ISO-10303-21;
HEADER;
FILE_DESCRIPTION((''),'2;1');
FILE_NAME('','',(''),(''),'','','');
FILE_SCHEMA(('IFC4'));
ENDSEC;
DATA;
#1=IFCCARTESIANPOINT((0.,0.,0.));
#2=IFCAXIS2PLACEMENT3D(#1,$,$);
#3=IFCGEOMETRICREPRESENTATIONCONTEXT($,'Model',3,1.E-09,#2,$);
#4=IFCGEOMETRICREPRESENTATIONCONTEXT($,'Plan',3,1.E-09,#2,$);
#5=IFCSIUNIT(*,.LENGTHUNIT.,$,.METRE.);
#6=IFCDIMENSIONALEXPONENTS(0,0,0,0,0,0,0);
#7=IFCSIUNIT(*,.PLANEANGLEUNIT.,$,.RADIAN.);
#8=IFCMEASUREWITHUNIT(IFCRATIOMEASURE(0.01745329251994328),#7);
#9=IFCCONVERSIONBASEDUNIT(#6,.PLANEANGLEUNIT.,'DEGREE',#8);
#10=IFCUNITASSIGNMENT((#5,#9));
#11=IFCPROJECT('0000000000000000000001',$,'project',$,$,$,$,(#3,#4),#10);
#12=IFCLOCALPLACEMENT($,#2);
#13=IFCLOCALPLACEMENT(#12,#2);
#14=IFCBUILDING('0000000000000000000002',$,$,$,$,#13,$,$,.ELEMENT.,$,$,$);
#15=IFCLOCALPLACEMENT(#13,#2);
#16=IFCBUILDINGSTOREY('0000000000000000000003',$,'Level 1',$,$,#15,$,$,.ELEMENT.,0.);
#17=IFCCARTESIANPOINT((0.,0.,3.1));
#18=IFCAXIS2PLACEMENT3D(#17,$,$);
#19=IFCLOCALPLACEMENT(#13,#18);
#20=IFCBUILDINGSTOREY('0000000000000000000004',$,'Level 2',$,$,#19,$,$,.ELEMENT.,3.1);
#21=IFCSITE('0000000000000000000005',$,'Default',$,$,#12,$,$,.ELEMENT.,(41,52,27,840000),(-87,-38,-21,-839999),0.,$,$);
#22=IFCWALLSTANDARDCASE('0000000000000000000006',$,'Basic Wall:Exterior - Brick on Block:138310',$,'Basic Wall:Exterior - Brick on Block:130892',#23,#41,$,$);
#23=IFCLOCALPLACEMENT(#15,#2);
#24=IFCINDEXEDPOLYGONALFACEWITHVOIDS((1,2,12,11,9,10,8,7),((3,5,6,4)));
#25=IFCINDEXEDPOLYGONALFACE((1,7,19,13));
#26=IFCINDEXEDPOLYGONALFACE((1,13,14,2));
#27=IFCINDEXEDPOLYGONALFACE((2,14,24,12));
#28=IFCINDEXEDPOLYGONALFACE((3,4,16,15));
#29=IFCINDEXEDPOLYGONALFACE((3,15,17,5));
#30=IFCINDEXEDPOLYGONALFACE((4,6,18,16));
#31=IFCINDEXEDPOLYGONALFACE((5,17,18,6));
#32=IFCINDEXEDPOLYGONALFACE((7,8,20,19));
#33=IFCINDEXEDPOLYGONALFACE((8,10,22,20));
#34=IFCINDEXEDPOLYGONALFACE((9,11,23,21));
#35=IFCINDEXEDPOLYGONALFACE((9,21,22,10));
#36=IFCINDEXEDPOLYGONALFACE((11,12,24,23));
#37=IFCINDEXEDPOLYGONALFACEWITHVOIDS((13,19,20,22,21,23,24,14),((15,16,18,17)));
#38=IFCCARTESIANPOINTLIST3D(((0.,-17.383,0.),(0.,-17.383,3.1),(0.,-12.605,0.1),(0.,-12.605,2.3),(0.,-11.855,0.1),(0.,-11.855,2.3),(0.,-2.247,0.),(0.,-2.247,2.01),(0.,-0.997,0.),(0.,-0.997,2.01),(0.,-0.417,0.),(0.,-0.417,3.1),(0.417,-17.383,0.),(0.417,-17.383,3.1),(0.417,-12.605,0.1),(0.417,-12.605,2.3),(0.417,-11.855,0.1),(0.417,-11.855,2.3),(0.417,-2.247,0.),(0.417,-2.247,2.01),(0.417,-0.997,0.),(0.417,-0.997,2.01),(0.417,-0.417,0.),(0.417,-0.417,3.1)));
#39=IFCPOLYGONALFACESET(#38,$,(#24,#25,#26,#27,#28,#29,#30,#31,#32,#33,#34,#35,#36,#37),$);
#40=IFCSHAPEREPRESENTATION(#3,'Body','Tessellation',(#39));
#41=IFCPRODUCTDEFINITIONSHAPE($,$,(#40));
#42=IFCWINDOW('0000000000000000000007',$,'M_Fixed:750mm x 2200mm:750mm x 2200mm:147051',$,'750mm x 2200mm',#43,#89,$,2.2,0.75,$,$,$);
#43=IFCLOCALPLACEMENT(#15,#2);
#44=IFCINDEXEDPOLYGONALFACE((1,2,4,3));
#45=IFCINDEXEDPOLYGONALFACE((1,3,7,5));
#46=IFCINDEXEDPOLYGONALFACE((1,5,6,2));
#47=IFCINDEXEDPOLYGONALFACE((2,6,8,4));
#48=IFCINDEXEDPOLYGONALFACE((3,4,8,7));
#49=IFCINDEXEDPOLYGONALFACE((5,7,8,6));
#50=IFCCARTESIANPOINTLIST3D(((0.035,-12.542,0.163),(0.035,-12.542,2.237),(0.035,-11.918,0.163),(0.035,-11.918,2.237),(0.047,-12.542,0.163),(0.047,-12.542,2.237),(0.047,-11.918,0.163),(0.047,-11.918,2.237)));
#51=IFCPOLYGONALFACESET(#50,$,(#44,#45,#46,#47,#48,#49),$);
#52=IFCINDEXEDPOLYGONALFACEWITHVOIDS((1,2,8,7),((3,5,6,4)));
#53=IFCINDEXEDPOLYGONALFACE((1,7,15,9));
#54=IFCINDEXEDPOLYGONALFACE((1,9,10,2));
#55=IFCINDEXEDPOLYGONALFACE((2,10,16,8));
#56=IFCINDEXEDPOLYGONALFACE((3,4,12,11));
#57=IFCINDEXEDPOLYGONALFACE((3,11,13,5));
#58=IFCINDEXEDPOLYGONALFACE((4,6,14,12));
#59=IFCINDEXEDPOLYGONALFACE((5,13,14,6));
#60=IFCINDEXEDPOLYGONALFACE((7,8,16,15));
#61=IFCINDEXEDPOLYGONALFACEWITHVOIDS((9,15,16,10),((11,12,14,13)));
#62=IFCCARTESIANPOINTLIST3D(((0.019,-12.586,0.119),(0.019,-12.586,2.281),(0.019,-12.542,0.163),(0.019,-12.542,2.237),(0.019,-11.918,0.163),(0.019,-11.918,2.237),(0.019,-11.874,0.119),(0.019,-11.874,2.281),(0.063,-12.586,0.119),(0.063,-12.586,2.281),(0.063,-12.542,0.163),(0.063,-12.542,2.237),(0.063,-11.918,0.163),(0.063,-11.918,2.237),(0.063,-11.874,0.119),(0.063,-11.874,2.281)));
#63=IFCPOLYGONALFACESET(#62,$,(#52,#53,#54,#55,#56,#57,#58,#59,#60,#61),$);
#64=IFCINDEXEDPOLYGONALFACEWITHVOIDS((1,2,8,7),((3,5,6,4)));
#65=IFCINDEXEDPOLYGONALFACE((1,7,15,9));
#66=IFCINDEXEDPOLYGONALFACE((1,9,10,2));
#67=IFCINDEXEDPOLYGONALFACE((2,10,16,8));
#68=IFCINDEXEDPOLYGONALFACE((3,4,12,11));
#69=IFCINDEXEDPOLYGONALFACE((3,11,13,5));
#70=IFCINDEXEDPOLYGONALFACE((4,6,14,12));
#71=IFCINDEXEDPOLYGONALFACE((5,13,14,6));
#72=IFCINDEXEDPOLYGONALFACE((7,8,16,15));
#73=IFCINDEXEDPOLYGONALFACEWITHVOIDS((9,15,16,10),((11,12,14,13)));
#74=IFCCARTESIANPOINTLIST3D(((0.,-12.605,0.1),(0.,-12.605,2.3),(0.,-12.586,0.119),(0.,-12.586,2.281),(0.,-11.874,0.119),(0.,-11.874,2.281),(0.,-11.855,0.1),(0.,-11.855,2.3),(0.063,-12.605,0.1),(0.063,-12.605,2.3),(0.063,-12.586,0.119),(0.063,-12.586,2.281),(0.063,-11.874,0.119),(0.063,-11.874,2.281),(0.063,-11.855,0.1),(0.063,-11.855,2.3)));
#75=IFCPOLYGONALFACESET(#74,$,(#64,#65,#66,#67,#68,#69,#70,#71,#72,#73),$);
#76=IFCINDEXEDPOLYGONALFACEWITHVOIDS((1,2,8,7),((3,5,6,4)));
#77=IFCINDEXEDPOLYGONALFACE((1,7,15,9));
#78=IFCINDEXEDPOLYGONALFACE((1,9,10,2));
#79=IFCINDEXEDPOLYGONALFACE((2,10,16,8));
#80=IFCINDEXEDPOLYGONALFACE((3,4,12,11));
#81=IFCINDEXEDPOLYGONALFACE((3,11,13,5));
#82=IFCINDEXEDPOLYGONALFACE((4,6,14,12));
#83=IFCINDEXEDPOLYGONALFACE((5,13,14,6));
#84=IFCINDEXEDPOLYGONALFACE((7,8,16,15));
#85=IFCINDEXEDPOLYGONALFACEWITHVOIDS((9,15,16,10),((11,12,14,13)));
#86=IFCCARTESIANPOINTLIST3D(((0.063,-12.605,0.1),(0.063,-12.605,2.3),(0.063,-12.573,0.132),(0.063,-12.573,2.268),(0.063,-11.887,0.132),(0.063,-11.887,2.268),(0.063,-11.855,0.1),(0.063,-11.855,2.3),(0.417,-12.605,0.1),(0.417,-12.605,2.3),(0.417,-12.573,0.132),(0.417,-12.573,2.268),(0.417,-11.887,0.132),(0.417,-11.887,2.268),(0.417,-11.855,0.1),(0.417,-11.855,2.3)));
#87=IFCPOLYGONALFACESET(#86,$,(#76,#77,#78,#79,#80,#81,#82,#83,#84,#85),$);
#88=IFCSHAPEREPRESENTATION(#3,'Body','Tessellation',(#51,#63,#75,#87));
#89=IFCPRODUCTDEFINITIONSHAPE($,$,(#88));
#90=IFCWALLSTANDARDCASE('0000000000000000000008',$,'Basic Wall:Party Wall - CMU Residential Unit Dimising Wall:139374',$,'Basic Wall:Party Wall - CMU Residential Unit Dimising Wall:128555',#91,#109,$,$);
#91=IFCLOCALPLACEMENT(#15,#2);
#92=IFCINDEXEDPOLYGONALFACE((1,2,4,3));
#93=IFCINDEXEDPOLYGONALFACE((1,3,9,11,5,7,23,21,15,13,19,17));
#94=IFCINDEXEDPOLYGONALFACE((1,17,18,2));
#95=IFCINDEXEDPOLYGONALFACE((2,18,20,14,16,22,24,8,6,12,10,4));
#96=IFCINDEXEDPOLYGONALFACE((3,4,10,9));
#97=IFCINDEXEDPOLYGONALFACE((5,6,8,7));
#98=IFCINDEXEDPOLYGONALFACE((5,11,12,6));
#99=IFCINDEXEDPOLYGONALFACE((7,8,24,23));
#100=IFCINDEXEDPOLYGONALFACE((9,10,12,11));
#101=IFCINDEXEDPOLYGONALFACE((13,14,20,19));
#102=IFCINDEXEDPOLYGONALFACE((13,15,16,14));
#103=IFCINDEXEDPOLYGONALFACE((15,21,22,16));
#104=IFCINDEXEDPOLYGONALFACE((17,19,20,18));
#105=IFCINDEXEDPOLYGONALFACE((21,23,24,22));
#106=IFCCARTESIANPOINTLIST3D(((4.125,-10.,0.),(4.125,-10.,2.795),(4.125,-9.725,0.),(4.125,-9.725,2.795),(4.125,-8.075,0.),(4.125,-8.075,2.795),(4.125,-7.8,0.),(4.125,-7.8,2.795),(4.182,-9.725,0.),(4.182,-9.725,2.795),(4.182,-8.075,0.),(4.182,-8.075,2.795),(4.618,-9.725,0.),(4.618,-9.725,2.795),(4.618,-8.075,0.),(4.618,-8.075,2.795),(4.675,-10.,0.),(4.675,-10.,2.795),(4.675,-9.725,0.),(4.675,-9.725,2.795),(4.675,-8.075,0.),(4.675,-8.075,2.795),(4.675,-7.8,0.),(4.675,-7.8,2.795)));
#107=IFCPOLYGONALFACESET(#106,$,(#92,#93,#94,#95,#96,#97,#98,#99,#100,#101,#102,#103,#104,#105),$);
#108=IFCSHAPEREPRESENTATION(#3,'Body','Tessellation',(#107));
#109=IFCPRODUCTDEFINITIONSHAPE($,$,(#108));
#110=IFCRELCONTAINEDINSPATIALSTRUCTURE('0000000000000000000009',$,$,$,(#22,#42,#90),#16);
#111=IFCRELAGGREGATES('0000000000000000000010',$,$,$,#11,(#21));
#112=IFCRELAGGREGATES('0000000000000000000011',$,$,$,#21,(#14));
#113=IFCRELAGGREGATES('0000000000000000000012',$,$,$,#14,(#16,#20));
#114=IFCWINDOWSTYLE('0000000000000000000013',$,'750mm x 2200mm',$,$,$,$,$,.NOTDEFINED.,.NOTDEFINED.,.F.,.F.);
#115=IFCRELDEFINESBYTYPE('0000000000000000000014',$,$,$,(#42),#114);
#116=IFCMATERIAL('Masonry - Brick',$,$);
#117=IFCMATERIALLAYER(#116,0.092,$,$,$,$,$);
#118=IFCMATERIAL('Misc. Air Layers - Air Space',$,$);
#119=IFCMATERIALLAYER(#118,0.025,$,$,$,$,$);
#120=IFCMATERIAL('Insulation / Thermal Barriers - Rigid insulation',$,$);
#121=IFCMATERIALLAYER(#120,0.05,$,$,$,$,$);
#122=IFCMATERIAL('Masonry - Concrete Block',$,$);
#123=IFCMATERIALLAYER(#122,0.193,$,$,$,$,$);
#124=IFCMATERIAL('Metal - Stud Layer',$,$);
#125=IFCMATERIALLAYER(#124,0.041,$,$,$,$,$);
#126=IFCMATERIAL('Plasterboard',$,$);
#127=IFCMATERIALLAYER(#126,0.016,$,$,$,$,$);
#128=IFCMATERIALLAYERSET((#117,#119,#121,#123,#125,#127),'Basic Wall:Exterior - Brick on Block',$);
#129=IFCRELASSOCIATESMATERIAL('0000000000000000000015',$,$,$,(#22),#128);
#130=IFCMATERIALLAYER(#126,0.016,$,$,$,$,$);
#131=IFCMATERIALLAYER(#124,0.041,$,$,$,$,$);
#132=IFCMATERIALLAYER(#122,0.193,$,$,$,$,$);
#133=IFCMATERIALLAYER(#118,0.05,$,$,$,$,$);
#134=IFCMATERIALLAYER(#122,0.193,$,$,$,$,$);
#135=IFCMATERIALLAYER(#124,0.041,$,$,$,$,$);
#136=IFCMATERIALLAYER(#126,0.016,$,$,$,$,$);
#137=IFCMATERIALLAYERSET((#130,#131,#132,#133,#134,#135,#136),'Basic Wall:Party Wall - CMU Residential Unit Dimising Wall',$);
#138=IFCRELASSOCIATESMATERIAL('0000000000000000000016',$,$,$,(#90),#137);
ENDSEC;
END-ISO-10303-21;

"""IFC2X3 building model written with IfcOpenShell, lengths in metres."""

from ifc_helpers import new_model, entity, si_unit, converted_unit, frame, frame_2d, origin, origin_2d_with_axis, place, context, project, spatial, polyline, rectangle, outline, extrude, clip, bounded_halfspace, source, transform, mapped, material, layer, layer_set, layer_usage, type_object, type_shapes, element, fill, save


model = new_model("IFC2X3")

# Units and contexts
model_context = context("Model", 3, precision=1e-09, world=origin())
plan_context = context("Plan", 3, precision=1e-09, world=origin())
ifc_project = project(units=[si_unit("LENGTHUNIT", "METRE"), converted_unit("PLANEANGLEUNIT", "DEGREE", entity("IfcRatioMeasure", 0.01745329251994328), si_unit("PLANEANGLEUNIT", "RADIAN"), dimensions=[0, 0, 0, 0, 0, 0, 0])], contexts=[model_context, plan_context])

# Site, building, storey
site_placement = place(None, origin())
site = spatial("IfcSite", under=ifc_project, at=site_placement, Name="Default", CompositionType="ELEMENT", RefLatitude=(41, 52, 27, 840000), RefLongitude=(-87, -38, -21, -839999), RefElevation=0.0)
building_placement = place(site_placement, origin())
building = spatial("IfcBuilding", under=site, at=building_placement, CompositionType="ELEMENT")
storey_1_placement = place(building_placement, origin())
storey_1 = spatial("IfcBuildingStorey", under=building, at=storey_1_placement, Name="Level 1", CompositionType="ELEMENT", Elevation=0.0)

# Shared definitions
ifc_material_1 = material(Name="Masonry - Brick")
ifc_layer_1 = layer(ifc_material_1, 0.092)
ifc_material_2 = material(Name="Misc. Air Layers - Air Space")
ifc_layer_2 = layer(ifc_material_2, 0.025)
ifc_material_3 = material(Name="Insulation / Thermal Barriers - Rigid insulation")
ifc_layer_3 = layer(ifc_material_3, 0.05)
ifc_material_4 = material(Name="Masonry - Concrete Block")
ifc_layer_4 = layer(ifc_material_4, 0.193)
ifc_material_5 = material(Name="Metal - Stud Layer")
ifc_layer_5 = layer(ifc_material_5, 0.041)
ifc_material_6 = material(Name="Plasterboard")
ifc_layer_6 = layer(ifc_material_6, 0.016)
ifc_layer_set_1 = layer_set([ifc_layer_1, ifc_layer_2, ifc_layer_3, ifc_layer_4, ifc_layer_5, ifc_layer_6], Name="Basic Wall:Exterior - Brick on Block")

# Wall, openings, window
ifc_layer_usage_1 = layer_usage(ifc_layer_set_1, "AXIS2", "NEGATIVE", 0.2085)
wall_1_placement = place(storey_1_placement, frame((0.2085, -17.383, 0.0), z_axis=(0.0, 0.0, 1.0), x_axis=(0.0, 1.0, 0.0)))
wall_1 = element("IfcWallStandardCase", 1, at=wall_1_placement, inside=storey_1, material=ifc_layer_usage_1, Name="Basic Wall:Exterior - Brick on Block:138310", ObjectType="Basic Wall:Exterior - Brick on Block:130892", context=model_context, shape_type="SweptSolid", body=[
    extrude(rectangle(XDim=16.966, YDim=0.417, at=frame_2d((8.483, 0.0), x_axis=(-1.0, 0.0))), origin(), (0.0, 0.0, 1.0), 3.1),
])
opening_1_placement = place(wall_1_placement, frame((15.136, -0.2085, 0.0)))
element("IfcOpeningElement", 2, at=opening_1_placement, cuts=wall_1, ObjectType="Opening", context=model_context, shape_type="SweptSolid", body=[
    extrude(rectangle(XDim=1.25, YDim=2.01, at=frame_2d((1.005, 0.625), x_axis=(0.0, 1.0))), frame((0.0, 0.0, 0.0), z_axis=(0.0, 1.0, 0.0), x_axis=(0.0, 0.0, 1.0)), (0.0, 0.0, 1.0), 0.417),
])
opening_2_placement = place(wall_1_placement, frame((4.778, -0.2085, 0.1)))
opening_2 = element("IfcOpeningElement", 3, at=opening_2_placement, cuts=wall_1, ObjectType="Opening", context=model_context, shape_type="SweptSolid", body=[
    extrude(rectangle(XDim=2.2, YDim=0.75, at=frame_2d((1.1, 0.375), x_axis=(1.0, 0.0))), frame((0.0, 0.0, 0.0), z_axis=(0.0, 1.0, 0.0), x_axis=(0.0, 0.0, 1.0)), (0.0, 0.0, 1.0), 0.417),
])
window_style_1 = type_object("IfcWindowStyle", Name="750mm x 2200mm", ConstructionType="NOTDEFINED", OperationType="NOTDEFINED", ParameterTakesPrecedence=False, Sizeable=False)
shared_shape_1 = source(origin(), model_context, "Body", "SweptSolid", [
    extrude(rectangle(XDim=0.012, YDim=0.624, at=origin_2d_with_axis()), frame((0.375, 0.376, 0.063), z_axis=(0.0, 0.0, 1.0), x_axis=(0.0, -1.0, 0.0)), (0.0, 0.0, 1.0), 2.074),
    extrude(outline(polyline([(-0.356, -1.081), (0.356, -1.081), (0.356, 1.081), (-0.356, 1.081), (-0.356, -1.081)]), holes=[polyline([(-0.312, -1.037), (-0.312, 1.037), (0.312, 1.037), (0.312, -1.037), (-0.312, -1.037)])]), frame((0.375, 0.354, 1.1), z_axis=(0.0, 1.0, 0.0), x_axis=(1.0, 0.0, 0.0)), (0.0, 0.0, 1.0), 0.044),
    extrude(outline(polyline([(-0.375, -1.1), (0.375, -1.1), (0.375, 1.1), (-0.375, 1.1), (-0.375, -1.1)]), holes=[polyline([(-0.356, -1.081), (-0.356, 1.081), (0.356, 1.081), (0.356, -1.081), (-0.356, -1.081)])]), frame((0.375, 0.354, 1.1), z_axis=(0.0, 1.0, 0.0), x_axis=(1.0, 0.0, 0.0)), (0.0, 0.0, 1.0), 0.063),
    extrude(outline(polyline([(-0.375, -1.1), (0.375, -1.1), (0.375, 1.1), (-0.375, 1.1), (-0.375, -1.1)]), holes=[polyline([(-0.343, -1.068), (-0.343, 1.068), (0.343, 1.068), (0.343, -1.068), (-0.343, -1.068)])]), frame((0.375, 0.0, 1.1), z_axis=(0.0, 1.0, 0.0), x_axis=(1.0, 0.0, 0.0)), (0.0, 0.0, 1.0), 0.354),
])
type_shapes(window_style_1, [shared_shape_1])
window_1_placement = place(opening_2_placement, origin())
window_1 = element("IfcWindow", 4, at=window_1_placement, inside=storey_1, type_object=window_style_1, Name="M_Fixed:750mm x 2200mm:750mm x 2200mm:147051", ObjectType="750mm x 2200mm", OverallHeight=2.2, OverallWidth=0.75, context=model_context, shape_type="MappedRepresentation", body=[
    mapped(shared_shape_1, transform((0.0, 0.0, 0.0), scale=1.0)),
])
fill(opening_2, window_1)

# Wall
ifc_layer_7 = layer(ifc_material_6, 0.016)
ifc_layer_8 = layer(ifc_material_5, 0.041)
ifc_layer_9 = layer(ifc_material_4, 0.193)
ifc_layer_10 = layer(ifc_material_2, 0.05)
ifc_layer_11 = layer(ifc_material_4, 0.193)
ifc_layer_12 = layer(ifc_material_5, 0.041)
ifc_layer_13 = layer(ifc_material_6, 0.016)
ifc_layer_set_2 = layer_set([ifc_layer_7, ifc_layer_8, ifc_layer_9, ifc_layer_10, ifc_layer_11, ifc_layer_12, ifc_layer_13], Name="Basic Wall:Party Wall - CMU Residential Unit Dimising Wall")
ifc_layer_usage_2 = layer_usage(ifc_layer_set_2, "AXIS2", "NEGATIVE", 0.275)
wall_2_placement = place(storey_1_placement, frame((4.4, -10.0, 0.0), z_axis=(0.0, 0.0, 1.0), x_axis=(0.0, 1.0, 0.0)))
element("IfcWallStandardCase", 5, at=wall_2_placement, inside=storey_1, material=ifc_layer_usage_2, Name="Basic Wall:Party Wall - CMU Residential Unit Dimising Wall:139374", ObjectType="Basic Wall:Party Wall - CMU Residential Unit Dimising Wall:128555", context=model_context, shape_type="Clipping", body=[
    clip(clip(extrude(rectangle(XDim=2.2, YDim=0.55, at=frame_2d((1.1, 0.0), x_axis=(-1.0, 0.0))), origin(), (0.0, 0.0, 1.0), 2.795), bounded_halfspace(frame((1.925, 0.218, 0.0), z_axis=(0.0, -1.0, 0.0), x_axis=(1.0, 0.0, 0.0)), True, frame((1.925, 0.218, 0.0), z_axis=(0.0, -1.0, 0.0), x_axis=(1.0, 0.0, 0.0)), polyline([(0.0, 0.0), (0.0, 2.795), (-1.65, 2.795), (-1.65, 0.0), (0.0, 0.0)]))), bounded_halfspace(frame((0.275, -0.218, 0.0), z_axis=(0.0, 1.0, 0.0), x_axis=(-1.0, 0.0, 0.0)), True, frame((0.275, -0.218, 0.0), z_axis=(0.0, 1.0, 0.0), x_axis=(-1.0, 0.0, 0.0)), polyline([(0.0, 0.0), (0.0, 2.795), (-1.65, 2.795), (-1.65, 0.0), (0.0, 0.0)]))),
])

# Shared definitions
storey_2_placement = place(building_placement, frame((0.0, 0.0, 3.1)))
storey_2 = spatial("IfcBuildingStorey", under=building, at=storey_2_placement, Name="Level 2", CompositionType="ELEMENT", Elevation=3.1)

save(model, "model.ifc")
